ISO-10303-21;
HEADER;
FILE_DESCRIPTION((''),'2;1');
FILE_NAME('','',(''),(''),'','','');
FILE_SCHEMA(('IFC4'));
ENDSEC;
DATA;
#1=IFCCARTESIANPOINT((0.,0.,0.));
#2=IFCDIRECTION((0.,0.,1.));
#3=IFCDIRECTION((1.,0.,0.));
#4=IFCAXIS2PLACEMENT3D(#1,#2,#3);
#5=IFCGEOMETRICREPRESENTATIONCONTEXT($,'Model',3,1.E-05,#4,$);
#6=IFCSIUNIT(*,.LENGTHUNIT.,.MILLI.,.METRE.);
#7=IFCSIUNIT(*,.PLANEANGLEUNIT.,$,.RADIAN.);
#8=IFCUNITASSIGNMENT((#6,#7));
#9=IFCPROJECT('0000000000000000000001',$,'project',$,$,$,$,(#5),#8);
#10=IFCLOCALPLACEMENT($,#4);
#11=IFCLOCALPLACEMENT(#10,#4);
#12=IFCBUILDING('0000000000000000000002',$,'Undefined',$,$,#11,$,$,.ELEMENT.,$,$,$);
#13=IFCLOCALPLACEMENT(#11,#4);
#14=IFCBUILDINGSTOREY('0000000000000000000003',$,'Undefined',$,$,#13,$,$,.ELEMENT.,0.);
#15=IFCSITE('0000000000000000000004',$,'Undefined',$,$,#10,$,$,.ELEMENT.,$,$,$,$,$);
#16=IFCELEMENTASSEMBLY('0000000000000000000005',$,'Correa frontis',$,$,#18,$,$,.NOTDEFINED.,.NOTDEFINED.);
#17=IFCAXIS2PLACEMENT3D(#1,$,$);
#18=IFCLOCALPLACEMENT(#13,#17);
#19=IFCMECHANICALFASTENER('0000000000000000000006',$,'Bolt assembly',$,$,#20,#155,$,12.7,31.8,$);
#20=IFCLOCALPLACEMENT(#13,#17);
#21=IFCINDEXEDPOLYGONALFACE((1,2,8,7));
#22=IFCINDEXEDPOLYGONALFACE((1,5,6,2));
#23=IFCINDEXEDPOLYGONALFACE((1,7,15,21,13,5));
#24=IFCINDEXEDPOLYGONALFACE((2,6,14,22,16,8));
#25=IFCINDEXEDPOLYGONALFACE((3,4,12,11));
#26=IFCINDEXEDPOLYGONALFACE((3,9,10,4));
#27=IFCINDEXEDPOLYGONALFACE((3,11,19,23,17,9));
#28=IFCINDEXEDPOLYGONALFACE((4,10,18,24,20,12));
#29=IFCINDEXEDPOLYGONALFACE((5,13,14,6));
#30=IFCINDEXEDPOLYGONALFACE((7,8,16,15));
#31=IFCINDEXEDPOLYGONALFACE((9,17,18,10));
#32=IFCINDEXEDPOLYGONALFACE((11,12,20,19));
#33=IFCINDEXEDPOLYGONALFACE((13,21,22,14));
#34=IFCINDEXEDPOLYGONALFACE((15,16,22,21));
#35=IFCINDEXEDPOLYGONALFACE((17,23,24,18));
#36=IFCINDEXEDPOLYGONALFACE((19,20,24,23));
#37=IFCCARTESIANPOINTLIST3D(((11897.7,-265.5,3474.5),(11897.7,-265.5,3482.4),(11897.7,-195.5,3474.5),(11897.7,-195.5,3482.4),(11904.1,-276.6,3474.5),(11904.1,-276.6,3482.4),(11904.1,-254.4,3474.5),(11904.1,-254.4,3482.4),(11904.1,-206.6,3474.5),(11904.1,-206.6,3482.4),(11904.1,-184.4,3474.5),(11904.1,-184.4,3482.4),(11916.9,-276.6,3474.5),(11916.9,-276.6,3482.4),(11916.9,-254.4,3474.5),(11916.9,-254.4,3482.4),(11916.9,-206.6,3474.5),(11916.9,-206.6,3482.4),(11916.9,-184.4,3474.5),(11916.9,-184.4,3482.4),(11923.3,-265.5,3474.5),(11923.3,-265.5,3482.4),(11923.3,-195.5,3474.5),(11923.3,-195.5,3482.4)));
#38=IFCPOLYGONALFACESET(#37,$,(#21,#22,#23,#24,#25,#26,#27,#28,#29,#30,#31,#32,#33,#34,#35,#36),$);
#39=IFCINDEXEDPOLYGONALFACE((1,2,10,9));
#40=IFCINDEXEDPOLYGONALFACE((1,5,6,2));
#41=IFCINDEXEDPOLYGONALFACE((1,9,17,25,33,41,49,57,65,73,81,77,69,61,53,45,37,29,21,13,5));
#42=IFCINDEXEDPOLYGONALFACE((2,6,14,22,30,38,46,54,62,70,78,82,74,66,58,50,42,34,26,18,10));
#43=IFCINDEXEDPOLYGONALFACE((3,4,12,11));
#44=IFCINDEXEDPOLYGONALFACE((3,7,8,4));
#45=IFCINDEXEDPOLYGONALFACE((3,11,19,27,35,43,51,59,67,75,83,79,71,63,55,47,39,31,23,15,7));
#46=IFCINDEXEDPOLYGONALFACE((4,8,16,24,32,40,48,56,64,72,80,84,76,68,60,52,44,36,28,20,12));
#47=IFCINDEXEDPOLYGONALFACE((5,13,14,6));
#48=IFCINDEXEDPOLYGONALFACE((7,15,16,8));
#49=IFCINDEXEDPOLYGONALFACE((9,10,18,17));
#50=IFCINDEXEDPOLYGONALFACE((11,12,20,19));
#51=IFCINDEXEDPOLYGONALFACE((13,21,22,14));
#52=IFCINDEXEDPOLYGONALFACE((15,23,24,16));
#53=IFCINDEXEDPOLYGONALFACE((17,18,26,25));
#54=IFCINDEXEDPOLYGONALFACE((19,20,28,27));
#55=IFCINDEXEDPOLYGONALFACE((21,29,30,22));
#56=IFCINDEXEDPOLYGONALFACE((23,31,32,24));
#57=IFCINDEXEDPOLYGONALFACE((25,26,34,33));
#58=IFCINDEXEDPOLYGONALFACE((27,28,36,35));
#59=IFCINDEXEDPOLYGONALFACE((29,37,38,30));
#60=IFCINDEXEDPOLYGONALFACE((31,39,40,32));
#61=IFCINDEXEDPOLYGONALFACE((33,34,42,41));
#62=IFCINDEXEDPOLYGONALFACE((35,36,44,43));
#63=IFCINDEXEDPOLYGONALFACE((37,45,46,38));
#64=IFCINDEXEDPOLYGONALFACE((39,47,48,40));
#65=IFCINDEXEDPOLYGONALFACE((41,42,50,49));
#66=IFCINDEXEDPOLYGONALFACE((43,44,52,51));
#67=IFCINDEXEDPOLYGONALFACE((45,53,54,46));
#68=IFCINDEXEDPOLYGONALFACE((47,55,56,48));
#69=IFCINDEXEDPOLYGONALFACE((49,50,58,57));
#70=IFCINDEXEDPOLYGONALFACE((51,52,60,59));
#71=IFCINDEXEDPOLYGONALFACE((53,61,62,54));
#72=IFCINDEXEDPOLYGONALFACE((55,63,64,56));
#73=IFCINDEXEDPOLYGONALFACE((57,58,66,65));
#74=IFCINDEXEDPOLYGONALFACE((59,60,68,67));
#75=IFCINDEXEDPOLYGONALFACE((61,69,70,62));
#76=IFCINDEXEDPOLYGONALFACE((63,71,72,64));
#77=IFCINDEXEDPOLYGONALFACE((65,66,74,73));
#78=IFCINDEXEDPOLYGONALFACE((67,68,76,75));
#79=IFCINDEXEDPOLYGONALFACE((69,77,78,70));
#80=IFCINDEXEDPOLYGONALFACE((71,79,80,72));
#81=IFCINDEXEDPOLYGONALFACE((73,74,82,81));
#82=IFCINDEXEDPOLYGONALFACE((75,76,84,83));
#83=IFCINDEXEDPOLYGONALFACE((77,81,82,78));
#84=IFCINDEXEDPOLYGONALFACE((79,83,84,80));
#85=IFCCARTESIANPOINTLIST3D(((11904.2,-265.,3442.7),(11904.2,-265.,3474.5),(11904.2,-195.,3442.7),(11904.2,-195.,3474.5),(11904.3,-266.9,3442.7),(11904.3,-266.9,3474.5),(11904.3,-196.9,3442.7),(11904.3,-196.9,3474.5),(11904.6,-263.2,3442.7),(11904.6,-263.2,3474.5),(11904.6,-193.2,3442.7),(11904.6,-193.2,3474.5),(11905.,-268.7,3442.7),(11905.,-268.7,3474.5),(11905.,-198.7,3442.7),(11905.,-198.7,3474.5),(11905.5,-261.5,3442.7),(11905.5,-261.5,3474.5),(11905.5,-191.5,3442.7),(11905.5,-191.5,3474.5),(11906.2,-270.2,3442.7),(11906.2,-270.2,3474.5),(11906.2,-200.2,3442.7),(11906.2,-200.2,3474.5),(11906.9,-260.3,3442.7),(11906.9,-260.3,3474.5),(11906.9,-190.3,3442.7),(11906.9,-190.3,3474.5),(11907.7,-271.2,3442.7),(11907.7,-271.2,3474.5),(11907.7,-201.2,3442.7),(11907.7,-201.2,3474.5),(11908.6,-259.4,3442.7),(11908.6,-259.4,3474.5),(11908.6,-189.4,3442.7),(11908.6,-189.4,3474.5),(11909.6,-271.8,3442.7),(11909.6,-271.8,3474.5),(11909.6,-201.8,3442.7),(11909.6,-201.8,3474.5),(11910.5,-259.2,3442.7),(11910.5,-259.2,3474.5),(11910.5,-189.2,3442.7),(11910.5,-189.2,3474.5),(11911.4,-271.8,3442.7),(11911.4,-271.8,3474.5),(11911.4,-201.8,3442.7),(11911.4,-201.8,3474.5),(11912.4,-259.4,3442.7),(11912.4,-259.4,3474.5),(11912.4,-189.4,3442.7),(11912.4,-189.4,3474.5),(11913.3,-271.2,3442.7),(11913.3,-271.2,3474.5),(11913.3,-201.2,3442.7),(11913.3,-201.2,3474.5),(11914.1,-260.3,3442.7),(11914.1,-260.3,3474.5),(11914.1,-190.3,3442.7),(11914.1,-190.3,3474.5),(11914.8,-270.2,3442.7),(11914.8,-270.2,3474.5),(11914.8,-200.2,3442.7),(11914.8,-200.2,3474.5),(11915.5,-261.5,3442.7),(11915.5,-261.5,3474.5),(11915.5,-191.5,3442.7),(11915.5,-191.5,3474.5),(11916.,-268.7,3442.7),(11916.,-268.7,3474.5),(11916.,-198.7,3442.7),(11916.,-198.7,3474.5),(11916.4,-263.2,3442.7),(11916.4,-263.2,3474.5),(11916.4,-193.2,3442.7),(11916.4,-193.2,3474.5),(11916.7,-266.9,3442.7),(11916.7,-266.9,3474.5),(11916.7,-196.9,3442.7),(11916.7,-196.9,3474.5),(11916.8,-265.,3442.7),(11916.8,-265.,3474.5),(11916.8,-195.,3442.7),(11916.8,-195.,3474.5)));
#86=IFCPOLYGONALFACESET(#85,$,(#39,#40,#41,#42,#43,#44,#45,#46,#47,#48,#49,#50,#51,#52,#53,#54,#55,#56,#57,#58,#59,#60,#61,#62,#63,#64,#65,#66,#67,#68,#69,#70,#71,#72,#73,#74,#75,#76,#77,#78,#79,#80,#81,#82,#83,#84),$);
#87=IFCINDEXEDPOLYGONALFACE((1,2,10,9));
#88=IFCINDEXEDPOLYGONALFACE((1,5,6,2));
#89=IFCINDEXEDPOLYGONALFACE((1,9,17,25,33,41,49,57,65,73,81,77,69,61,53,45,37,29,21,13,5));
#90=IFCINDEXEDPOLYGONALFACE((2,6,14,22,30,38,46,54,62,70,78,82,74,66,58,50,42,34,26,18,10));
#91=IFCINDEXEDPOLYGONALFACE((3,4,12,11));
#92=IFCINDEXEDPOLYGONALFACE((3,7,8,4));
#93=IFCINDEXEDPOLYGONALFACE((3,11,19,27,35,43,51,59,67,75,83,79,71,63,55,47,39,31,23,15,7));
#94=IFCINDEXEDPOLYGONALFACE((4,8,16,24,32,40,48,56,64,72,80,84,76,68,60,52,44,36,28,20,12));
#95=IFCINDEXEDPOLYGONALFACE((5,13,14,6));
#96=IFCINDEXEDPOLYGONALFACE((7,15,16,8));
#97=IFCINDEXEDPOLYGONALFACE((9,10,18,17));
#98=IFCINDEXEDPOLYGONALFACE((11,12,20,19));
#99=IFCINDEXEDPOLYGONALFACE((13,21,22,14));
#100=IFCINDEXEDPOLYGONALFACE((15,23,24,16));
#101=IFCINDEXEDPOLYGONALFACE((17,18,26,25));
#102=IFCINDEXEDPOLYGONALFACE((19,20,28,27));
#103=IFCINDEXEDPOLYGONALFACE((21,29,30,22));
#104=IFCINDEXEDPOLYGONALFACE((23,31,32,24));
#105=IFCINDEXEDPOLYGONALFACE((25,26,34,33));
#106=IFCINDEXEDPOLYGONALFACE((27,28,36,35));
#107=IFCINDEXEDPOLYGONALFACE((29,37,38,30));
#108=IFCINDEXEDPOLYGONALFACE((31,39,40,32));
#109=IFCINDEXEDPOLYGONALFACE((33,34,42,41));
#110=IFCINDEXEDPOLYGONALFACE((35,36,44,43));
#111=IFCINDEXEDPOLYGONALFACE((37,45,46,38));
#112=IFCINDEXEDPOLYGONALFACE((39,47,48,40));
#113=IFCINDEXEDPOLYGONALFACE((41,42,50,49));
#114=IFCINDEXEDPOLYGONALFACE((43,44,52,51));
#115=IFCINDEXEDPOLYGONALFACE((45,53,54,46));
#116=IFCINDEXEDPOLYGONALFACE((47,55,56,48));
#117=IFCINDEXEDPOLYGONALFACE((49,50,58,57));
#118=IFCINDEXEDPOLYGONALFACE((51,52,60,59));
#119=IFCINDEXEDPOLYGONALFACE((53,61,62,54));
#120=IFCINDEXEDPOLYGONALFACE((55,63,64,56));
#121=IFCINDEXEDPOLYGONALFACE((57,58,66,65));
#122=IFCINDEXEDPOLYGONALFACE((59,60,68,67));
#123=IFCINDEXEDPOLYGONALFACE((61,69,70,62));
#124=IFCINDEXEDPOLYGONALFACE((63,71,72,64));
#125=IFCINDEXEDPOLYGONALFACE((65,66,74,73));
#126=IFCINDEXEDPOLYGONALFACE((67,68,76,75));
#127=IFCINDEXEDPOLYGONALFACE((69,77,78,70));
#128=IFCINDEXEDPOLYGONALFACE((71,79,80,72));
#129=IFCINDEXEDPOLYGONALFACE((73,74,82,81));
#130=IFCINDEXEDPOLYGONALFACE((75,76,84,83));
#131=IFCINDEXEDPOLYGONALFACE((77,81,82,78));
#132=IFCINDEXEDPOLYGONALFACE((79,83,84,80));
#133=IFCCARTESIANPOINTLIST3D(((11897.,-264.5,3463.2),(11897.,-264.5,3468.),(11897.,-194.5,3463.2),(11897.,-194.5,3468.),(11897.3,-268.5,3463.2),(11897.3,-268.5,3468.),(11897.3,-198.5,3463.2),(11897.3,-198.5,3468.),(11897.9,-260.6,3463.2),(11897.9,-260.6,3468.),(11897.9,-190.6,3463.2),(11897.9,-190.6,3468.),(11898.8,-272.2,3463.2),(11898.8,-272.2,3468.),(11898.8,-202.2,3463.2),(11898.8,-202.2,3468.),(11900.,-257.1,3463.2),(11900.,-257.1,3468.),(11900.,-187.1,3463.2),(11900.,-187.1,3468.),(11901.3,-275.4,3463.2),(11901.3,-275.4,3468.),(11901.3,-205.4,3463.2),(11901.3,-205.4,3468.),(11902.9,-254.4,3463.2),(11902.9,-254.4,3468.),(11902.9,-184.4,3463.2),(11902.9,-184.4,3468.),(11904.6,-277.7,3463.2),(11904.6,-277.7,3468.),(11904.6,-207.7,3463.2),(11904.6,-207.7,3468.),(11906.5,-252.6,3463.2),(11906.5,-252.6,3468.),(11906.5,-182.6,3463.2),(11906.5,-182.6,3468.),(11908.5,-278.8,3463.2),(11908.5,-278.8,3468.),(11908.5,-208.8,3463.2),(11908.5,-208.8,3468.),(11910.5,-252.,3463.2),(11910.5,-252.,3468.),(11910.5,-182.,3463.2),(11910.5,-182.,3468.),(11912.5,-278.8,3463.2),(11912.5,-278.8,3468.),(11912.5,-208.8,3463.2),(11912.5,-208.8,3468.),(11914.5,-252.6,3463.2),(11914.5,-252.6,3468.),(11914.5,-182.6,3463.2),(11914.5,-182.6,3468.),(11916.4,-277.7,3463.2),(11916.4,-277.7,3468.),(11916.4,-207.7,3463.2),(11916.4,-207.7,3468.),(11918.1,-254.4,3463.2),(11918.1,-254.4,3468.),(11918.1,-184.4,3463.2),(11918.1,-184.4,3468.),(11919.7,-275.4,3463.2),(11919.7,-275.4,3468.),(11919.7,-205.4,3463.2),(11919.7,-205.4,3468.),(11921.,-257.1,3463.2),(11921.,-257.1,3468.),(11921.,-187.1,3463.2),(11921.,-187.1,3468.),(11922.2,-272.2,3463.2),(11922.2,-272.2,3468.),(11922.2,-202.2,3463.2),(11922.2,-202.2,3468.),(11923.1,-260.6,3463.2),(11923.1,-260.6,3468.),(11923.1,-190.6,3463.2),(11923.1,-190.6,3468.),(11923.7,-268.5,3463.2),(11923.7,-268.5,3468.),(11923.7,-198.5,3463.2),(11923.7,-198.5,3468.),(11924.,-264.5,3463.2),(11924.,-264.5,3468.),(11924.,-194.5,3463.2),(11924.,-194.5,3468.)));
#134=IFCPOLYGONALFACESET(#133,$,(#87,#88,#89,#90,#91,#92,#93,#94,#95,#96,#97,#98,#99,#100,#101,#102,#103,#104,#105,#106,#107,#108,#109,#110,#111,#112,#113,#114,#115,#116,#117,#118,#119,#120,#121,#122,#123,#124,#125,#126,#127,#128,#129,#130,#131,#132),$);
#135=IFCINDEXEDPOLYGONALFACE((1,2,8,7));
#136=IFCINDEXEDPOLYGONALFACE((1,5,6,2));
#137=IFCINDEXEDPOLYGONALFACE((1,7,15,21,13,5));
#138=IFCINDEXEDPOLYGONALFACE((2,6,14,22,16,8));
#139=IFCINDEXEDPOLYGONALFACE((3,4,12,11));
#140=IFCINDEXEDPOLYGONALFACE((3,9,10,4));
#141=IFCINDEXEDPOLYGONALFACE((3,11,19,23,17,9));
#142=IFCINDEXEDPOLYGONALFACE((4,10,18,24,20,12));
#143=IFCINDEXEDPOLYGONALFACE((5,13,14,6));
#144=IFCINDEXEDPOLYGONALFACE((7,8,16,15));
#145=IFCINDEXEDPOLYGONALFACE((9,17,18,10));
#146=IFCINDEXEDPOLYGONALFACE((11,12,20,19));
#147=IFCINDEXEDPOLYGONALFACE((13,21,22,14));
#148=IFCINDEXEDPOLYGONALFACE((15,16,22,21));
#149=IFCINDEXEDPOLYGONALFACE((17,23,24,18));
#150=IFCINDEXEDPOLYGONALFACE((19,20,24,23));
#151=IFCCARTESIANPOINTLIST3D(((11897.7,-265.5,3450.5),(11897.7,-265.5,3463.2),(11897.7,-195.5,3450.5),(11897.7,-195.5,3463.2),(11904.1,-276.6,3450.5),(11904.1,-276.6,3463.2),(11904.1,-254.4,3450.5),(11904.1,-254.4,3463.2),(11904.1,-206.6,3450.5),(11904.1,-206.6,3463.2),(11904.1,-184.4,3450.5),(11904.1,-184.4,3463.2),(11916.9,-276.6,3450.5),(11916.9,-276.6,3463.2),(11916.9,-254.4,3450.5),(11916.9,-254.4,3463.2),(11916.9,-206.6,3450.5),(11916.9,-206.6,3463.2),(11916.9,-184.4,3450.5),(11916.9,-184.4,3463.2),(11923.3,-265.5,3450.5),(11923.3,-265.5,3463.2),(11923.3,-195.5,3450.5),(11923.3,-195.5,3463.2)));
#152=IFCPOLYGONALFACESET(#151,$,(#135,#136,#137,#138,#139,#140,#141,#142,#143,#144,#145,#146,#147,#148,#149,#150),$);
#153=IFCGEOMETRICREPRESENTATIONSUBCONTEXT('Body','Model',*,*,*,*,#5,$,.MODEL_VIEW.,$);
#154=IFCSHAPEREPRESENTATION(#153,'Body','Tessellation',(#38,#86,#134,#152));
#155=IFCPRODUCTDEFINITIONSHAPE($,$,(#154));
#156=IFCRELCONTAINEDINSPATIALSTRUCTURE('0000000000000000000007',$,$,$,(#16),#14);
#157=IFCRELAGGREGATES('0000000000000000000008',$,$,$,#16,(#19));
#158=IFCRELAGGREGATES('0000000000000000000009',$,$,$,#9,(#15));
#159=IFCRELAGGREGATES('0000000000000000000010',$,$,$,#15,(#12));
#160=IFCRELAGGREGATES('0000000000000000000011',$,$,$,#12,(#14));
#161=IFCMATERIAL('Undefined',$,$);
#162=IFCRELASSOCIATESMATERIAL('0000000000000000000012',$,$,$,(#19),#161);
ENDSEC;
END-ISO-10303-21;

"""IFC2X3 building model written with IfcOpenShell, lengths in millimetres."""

from ifc_helpers import new_model, si_unit, frame, origin_with_axes, origin_2d_with_axis, place, context, subcontext, project, spatial, polyline, circle, outline, extrude, source, transform, mapped, material, element, aggregate, save


model = new_model("IFC2X3")

# Units and contexts
model_context = context("Model", 3, precision=1e-05, world=origin_with_axes())
body_context = subcontext(model_context, "Body", "Model", "MODEL_VIEW")
ifc_project = project(units=[si_unit("LENGTHUNIT", "METRE", prefix="MILLI"), si_unit("PLANEANGLEUNIT", "RADIAN")], contexts=[model_context])

# Site, building, storey
site_placement = place(None, origin_with_axes())
site = spatial("IfcSite", under=ifc_project, at=site_placement, Name="Undefined", CompositionType="ELEMENT")
building_placement = place(site_placement, origin_with_axes())
building = spatial("IfcBuilding", under=site, at=building_placement, Name="Undefined", CompositionType="ELEMENT")
storey_placement = place(building_placement, origin_with_axes())
storey = spatial("IfcBuildingStorey", under=building, at=storey_placement, Name="Undefined", CompositionType="ELEMENT", Elevation=0.0)

# Element assembly
assembly_1_placement = place(storey_placement, origin_with_axes())
assembly_1 = element("IfcElementAssembly", 1, at=assembly_1_placement, inside=storey, Name="Correa frontis", AssemblyPlace="NOTDEFINED", PredefinedType="NOTDEFINED")

# Mechanical fastener
ifc_material_1 = material(Name="Undefined")
shared_shape_1 = source(origin_with_axes(), body_context, "Body", "SweptSolid", [
    extrude(outline(polyline([(11.1, -6.4), (11.1, 6.4), (0.0, 12.8), (-11.1, 6.4), (-11.1, -6.4), (0.0, -12.8), (11.1, -6.4)])), frame((0.0, -12.4, 0.0), z_axis=(0.0, 1.0, 0.0), x_axis=(1.0, 0.0, 0.0)), (0.0, 0.0, 1.0), 7.9),
    extrude(circle(Radius=6.3, at=origin_2d_with_axis()), frame((0.0, -4.5, 0.0), z_axis=(0.0, 1.0, 0.0), x_axis=(1.0, 0.0, 0.0)), (0.0, 0.0, 1.0), 31.8),
    extrude(circle(Radius=13.5, at=origin_2d_with_axis()), frame((0.0, 2.0, 0.0), z_axis=(0.0, 1.0, 0.0), x_axis=(1.0, 0.0, 0.0)), (0.0, 0.0, 1.0), 4.8),
    extrude(outline(polyline([(11.1, -6.4), (11.1, 6.4), (0.0, 12.8), (-11.1, 6.4), (-11.1, -6.4), (0.0, -12.8), (11.1, -6.4)])), frame((0.0, 6.8, 0.0), z_axis=(0.0, 1.0, 0.0), x_axis=(1.0, 0.0, 0.0)), (0.0, 0.0, 1.0), 12.7),
])
mechanical_fastener_1_placement = place(assembly_1_placement, frame((11910.5, -265.5, 3470.0), z_axis=(-1.0, 0.0, 0.0), x_axis=(0.0, 1.0, 0.0)))
mechanical_fastener_1 = element("IfcMechanicalFastener", 2, at=mechanical_fastener_1_placement, material=ifc_material_1, Name="Bolt assembly", NominalDiameter=12.7, NominalLength=31.8, context=body_context, shape_type="MappedRepresentation", body=[
    mapped(shared_shape_1, transform((0.0, 0.0, 0.0))),
    mapped(shared_shape_1, transform((70.0, 0.0, 0.0))),
])
aggregate(assembly_1, [mechanical_fastener_1])

save(model, "model.ifc")
